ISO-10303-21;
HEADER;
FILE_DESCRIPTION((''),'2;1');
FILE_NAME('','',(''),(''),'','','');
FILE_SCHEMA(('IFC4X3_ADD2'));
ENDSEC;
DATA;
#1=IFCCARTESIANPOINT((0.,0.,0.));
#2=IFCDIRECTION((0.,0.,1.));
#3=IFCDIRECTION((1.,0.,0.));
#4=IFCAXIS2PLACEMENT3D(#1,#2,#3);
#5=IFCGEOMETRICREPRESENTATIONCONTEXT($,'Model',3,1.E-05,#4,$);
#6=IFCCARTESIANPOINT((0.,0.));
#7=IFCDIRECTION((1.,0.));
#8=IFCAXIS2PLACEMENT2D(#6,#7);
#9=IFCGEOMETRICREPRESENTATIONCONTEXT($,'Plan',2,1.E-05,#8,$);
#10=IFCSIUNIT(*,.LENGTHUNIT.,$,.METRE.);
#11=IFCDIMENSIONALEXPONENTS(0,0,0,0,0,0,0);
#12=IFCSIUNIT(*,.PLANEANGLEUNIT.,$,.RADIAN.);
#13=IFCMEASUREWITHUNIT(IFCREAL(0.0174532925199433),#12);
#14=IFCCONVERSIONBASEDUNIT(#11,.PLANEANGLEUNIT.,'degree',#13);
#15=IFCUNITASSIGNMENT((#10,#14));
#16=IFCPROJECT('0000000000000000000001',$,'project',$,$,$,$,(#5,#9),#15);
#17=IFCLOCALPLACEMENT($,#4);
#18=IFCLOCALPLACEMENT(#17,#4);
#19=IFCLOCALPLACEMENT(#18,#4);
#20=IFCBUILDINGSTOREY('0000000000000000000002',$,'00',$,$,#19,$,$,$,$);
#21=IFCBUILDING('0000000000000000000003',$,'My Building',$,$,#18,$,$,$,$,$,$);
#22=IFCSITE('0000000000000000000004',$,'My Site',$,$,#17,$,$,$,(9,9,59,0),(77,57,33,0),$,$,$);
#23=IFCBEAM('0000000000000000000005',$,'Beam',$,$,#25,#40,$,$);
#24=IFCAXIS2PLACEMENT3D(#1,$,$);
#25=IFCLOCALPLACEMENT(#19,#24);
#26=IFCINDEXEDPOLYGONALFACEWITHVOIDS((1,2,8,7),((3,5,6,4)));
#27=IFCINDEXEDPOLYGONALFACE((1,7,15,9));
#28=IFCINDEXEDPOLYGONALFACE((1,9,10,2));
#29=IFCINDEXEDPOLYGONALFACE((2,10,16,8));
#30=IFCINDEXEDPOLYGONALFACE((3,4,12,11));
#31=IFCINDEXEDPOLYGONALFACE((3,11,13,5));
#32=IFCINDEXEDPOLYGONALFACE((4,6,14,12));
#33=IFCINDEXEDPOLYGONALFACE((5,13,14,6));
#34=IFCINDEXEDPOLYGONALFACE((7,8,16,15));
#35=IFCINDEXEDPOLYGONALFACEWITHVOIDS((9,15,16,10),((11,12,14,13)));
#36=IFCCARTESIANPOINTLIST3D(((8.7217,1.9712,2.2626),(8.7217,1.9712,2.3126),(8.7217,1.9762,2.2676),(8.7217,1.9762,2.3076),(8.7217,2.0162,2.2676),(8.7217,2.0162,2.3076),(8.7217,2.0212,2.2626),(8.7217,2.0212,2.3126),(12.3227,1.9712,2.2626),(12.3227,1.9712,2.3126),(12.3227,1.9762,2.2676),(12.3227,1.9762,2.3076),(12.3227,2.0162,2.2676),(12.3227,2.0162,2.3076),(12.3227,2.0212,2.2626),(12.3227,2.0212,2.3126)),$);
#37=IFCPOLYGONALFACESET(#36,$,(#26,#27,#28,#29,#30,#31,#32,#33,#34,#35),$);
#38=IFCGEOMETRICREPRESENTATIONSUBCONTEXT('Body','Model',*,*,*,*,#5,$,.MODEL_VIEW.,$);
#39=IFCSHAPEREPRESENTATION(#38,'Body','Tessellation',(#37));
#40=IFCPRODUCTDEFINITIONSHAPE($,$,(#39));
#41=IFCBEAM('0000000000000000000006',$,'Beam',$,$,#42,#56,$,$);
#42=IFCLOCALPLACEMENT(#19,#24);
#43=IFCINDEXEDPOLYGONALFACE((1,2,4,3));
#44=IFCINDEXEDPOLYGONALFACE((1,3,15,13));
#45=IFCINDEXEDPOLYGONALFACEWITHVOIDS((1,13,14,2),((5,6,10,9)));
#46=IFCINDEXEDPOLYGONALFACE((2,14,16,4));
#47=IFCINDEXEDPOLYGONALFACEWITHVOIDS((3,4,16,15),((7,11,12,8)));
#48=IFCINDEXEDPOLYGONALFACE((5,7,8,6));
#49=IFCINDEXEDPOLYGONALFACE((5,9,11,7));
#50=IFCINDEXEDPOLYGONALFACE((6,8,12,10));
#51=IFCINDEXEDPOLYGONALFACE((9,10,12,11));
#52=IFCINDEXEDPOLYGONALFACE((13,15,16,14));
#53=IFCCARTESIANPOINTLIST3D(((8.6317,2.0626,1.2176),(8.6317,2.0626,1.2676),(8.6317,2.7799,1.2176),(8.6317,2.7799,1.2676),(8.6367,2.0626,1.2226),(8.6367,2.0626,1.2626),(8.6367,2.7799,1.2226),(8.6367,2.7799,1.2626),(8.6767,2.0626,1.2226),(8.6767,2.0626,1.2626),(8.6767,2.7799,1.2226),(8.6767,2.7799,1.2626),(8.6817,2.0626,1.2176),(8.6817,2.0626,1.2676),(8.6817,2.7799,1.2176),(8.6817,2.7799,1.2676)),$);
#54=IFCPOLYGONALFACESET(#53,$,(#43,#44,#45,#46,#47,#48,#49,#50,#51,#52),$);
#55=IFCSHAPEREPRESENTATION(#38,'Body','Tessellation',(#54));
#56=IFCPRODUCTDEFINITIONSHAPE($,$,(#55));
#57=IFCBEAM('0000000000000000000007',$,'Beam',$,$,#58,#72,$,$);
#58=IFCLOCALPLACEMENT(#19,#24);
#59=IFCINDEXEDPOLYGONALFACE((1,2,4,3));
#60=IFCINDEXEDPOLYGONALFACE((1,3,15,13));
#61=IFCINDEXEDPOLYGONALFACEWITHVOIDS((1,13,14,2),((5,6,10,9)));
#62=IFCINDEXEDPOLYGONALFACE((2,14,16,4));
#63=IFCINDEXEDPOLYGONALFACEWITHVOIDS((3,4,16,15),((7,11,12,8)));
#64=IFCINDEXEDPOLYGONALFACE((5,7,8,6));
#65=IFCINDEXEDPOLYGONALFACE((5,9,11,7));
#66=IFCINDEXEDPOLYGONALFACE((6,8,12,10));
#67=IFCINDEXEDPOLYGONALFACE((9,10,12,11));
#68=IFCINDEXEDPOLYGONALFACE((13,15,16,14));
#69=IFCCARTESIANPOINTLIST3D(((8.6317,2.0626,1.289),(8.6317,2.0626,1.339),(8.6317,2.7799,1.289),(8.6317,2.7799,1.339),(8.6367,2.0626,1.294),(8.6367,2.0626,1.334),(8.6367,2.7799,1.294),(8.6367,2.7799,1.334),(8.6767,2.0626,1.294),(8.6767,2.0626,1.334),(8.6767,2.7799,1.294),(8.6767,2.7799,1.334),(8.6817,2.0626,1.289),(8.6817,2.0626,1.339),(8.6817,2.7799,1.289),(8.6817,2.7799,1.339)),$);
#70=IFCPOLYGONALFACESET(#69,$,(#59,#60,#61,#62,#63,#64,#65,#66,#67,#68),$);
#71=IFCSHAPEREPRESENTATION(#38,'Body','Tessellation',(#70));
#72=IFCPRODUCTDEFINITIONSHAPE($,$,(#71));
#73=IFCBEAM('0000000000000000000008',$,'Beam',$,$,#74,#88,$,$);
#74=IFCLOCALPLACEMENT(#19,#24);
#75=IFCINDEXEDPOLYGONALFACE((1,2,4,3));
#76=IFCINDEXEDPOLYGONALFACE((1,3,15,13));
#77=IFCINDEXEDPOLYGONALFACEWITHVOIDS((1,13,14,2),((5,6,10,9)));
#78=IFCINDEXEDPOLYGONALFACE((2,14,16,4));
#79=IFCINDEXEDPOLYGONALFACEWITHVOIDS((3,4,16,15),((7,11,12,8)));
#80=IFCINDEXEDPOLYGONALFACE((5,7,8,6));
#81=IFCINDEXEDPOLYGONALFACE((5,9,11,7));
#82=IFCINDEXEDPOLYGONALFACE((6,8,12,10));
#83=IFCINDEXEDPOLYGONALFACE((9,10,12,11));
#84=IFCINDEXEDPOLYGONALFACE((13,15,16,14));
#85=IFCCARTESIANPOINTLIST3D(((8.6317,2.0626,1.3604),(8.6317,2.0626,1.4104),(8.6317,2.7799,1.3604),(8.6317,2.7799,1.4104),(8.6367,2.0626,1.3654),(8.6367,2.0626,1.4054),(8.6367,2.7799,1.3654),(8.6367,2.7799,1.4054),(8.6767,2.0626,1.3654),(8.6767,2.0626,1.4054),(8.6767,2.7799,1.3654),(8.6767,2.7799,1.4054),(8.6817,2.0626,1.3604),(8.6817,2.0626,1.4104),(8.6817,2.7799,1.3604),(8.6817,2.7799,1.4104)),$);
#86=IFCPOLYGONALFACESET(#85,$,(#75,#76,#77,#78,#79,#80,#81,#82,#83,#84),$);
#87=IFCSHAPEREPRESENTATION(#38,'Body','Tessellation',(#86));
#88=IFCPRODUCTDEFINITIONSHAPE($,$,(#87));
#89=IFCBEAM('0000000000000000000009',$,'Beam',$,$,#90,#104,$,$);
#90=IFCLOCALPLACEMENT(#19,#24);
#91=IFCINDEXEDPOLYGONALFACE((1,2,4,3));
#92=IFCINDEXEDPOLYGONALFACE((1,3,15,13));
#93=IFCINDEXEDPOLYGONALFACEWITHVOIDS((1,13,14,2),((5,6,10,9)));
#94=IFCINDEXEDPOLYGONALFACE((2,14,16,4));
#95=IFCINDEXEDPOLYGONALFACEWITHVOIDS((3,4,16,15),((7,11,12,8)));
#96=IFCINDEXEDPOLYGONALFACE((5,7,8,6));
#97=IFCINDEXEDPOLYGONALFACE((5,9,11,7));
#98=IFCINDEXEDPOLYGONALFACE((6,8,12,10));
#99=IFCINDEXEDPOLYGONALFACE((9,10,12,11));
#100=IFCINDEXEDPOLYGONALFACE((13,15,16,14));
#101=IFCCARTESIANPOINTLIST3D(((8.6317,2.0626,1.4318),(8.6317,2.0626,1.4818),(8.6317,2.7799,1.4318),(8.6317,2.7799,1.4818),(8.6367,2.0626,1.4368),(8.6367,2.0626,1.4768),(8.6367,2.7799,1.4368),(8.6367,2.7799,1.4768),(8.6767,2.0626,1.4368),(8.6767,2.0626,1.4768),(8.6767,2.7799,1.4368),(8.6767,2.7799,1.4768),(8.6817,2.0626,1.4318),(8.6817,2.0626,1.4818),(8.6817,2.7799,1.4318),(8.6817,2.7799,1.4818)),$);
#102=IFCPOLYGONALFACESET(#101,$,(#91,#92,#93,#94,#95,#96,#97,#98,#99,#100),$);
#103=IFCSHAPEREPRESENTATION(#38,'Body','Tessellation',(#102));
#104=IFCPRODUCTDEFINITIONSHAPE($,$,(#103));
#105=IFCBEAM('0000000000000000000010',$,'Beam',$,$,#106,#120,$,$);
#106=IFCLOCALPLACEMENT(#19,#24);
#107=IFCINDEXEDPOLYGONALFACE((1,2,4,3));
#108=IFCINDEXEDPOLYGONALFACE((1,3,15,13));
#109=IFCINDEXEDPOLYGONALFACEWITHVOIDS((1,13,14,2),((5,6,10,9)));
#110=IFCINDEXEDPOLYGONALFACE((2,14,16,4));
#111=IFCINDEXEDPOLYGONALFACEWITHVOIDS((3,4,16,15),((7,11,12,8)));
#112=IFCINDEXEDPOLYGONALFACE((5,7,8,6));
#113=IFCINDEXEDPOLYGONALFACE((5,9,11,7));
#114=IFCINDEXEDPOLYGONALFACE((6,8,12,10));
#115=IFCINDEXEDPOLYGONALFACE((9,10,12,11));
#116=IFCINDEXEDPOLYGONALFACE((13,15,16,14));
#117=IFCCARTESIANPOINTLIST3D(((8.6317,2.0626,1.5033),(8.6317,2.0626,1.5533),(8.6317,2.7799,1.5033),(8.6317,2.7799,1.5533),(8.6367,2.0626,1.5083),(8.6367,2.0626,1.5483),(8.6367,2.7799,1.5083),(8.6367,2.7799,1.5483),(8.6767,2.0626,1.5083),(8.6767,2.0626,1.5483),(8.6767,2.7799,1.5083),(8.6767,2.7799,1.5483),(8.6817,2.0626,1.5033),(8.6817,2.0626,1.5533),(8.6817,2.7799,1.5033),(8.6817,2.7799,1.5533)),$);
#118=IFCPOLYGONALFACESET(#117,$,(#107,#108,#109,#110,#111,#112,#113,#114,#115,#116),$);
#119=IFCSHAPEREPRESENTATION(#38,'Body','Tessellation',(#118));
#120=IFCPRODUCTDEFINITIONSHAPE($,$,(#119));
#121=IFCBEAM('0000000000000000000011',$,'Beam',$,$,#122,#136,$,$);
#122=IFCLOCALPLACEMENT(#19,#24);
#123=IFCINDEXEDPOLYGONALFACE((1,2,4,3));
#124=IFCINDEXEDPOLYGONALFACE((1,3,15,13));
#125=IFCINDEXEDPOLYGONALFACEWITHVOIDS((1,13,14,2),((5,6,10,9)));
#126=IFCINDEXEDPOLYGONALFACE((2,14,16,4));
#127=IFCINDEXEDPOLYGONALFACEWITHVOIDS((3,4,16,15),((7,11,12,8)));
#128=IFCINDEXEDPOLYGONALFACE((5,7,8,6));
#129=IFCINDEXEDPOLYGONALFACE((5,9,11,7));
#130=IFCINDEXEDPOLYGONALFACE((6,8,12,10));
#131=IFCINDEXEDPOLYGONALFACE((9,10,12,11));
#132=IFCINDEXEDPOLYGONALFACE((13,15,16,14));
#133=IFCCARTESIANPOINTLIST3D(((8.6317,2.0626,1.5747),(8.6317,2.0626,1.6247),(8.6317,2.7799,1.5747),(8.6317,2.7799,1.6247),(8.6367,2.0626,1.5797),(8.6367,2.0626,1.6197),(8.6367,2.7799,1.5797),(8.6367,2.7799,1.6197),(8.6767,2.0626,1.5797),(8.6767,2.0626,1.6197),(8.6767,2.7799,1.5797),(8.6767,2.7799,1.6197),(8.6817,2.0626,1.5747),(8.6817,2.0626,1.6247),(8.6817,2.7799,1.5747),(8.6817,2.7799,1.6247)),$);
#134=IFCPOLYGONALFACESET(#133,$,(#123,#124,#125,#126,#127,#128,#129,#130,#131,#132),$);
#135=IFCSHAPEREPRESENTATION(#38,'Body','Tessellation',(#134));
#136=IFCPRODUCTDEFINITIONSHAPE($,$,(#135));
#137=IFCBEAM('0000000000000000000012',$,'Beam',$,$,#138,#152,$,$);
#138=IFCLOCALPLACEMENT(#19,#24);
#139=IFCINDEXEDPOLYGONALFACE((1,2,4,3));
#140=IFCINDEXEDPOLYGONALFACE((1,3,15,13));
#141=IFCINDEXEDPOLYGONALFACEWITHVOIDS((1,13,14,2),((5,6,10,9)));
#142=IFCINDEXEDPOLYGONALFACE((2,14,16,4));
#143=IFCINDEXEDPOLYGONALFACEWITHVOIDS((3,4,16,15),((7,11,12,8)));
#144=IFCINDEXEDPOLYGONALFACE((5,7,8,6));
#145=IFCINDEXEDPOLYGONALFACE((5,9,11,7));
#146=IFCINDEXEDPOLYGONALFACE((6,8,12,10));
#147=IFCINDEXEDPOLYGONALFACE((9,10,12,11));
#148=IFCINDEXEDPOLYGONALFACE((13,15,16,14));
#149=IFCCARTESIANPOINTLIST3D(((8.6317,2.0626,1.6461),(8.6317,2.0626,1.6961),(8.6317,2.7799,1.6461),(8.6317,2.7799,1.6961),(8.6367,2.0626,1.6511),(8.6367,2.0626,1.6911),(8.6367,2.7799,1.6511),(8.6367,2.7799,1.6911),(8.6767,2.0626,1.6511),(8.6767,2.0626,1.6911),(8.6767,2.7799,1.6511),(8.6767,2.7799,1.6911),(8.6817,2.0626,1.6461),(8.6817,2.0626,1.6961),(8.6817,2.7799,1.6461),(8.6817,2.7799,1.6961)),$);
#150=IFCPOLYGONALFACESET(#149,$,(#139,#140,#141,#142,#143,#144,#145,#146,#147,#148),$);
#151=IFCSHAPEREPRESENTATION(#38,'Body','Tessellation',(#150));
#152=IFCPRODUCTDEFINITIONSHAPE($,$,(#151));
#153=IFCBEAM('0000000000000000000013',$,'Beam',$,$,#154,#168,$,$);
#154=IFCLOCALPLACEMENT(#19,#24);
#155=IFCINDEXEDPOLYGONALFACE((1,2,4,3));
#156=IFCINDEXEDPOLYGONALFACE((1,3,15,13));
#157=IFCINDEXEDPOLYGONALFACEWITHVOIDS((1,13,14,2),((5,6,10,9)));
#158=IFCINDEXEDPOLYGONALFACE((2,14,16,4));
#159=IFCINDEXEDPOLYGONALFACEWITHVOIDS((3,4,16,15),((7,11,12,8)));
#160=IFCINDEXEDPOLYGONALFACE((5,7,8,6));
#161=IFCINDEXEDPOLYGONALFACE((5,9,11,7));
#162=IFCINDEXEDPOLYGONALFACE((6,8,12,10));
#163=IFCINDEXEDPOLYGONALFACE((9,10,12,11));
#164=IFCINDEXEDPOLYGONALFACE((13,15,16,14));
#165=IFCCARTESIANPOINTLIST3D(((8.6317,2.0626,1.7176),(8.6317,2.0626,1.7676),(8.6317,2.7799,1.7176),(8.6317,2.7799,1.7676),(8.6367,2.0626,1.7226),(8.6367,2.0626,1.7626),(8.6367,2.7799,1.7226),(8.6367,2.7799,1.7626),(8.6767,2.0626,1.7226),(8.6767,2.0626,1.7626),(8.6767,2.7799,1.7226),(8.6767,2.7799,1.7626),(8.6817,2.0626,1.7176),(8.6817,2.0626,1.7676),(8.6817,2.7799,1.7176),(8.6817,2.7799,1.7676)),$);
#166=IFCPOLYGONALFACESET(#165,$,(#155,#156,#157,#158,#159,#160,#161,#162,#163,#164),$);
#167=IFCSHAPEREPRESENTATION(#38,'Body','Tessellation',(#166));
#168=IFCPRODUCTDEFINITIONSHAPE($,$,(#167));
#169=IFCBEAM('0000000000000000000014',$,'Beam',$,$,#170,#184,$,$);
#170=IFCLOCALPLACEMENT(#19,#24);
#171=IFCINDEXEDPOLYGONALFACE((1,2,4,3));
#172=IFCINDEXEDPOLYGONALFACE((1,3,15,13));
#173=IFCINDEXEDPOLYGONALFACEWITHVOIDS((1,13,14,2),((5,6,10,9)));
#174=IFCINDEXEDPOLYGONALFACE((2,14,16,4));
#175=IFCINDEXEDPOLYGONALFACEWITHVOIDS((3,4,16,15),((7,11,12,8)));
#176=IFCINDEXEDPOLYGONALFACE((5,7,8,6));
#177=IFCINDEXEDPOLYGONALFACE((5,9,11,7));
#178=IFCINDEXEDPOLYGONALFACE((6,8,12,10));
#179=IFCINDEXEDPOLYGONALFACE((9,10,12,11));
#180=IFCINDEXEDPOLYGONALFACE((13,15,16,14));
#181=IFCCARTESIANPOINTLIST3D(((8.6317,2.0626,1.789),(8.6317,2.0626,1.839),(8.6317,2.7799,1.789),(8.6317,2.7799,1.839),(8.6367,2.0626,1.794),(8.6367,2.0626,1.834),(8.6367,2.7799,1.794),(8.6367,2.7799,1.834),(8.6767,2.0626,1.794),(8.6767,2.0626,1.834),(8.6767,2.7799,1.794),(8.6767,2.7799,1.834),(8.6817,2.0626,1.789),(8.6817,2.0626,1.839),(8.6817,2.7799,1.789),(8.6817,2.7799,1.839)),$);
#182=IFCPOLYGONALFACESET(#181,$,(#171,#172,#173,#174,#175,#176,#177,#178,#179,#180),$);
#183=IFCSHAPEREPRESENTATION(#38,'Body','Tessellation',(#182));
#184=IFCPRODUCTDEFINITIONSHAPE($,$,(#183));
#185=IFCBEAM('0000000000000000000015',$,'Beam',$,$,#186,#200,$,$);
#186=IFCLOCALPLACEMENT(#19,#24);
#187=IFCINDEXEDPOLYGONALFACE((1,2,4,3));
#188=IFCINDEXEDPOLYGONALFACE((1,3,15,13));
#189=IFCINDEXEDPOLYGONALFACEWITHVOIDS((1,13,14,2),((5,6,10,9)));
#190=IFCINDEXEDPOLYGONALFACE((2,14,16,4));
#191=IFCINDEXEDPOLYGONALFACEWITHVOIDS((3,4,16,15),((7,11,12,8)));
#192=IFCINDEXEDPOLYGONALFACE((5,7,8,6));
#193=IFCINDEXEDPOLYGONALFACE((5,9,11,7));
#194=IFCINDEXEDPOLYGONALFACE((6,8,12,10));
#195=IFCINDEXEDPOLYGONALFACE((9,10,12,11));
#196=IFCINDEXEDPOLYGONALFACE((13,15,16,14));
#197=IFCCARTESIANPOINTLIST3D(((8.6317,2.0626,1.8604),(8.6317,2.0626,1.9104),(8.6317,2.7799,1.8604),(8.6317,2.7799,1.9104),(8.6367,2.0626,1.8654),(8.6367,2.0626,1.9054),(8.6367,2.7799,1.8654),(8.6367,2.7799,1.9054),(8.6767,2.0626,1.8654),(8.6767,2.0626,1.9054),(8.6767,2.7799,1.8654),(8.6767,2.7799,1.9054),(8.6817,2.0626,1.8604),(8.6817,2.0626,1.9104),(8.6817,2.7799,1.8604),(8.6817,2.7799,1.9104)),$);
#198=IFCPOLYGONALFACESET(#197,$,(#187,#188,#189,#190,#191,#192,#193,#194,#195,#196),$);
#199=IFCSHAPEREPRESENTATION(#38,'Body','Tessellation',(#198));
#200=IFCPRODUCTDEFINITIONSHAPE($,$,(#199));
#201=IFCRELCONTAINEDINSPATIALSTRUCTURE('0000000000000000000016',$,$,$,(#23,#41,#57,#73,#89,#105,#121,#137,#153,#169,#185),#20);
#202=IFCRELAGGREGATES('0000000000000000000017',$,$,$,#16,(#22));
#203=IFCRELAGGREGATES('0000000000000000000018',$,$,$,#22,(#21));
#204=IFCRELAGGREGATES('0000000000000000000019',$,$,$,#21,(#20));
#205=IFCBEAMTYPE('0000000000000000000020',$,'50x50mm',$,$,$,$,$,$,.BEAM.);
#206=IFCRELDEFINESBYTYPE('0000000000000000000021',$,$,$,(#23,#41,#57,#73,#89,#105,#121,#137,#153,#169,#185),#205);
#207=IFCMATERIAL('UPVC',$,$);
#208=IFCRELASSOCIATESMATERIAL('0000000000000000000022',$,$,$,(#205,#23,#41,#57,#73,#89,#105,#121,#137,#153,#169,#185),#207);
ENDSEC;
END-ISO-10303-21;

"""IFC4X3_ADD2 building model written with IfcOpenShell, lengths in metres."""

from ifc_helpers import new_model, entity, si_unit, converted_unit, frame, origin_with_axes, origin_2d_with_axis, place, context, subcontext, project, spatial, hollow_rectangle, extrude, material, material_profile, profile_set, profile_usage, type_object, element, save


model = new_model("IFC4X3_ADD2")

# Units and contexts
model_context = context("Model", 3, precision=1e-05, world=origin_with_axes())
plan_context = context("Plan", 2, precision=1e-05, world=origin_2d_with_axis())
body_context = subcontext(model_context, "Body", "Model", "MODEL_VIEW")
ifc_project = project(units=[si_unit("LENGTHUNIT", "METRE"), converted_unit("PLANEANGLEUNIT", "degree", entity("IfcReal", 0.0174532925199433), si_unit("PLANEANGLEUNIT", "RADIAN"), dimensions=[0, 0, 0, 0, 0, 0, 0])], contexts=[model_context, plan_context])

# Site, building, storey
site_placement = place(None, origin_with_axes())
site = spatial("IfcSite", under=ifc_project, at=site_placement, Name="My Site", RefLatitude=(9, 9, 59, 0), RefLongitude=(77, 57, 33, 0))
building_placement = place(site_placement, origin_with_axes())
building = spatial("IfcBuilding", under=site, at=building_placement, Name="My Building")
storey_placement = place(building_placement, origin_with_axes())
storey = spatial("IfcBuildingStorey", under=building, at=storey_placement, Name="00")

# Beams
ifc_material_1 = material(Name="UPVC")
ifc_material_profile_1 = material_profile(ifc_material_1, hollow_rectangle(XDim=0.05, YDim=0.05, WallThickness=0.005))
ifc_profile_set_1 = profile_set([ifc_material_profile_1])
beam_type = type_object("IfcBeamType", Name="50x50mm", PredefinedType="BEAM", material=ifc_profile_set_1)
ifc_profile_usage_1 = profile_usage(ifc_profile_set_1, cardinal=5)
beam_1_placement = place(storey_placement, frame((8.7217, 1.9962, 2.2876), z_axis=(1.0, 0.0, 0.000001), x_axis=(0.0, 1.0, 0.0)))
element("IfcBeam", 1, at=beam_1_placement, inside=storey, type_object=beam_type, material=ifc_profile_usage_1, Name="Beam", context=body_context, shape_type="SweptSolid", body=[
    extrude(hollow_rectangle(XDim=0.05, YDim=0.05, WallThickness=0.005), origin_with_axes(), (0.0, 0.0, 1.0), 3.601),
])
ifc_profile_usage_2 = profile_usage(ifc_profile_set_1, cardinal=5)
beam_2_placement = place(storey_placement, frame((8.6567, 2.0626, 1.2426), z_axis=(0.0, 1.0, 0.000001), x_axis=(-1.0, 0.0, 0.0)))
element("IfcBeam", 2, at=beam_2_placement, inside=storey, type_object=beam_type, material=ifc_profile_usage_2, Name="Beam", context=body_context, shape_type="SweptSolid", body=[
    extrude(hollow_rectangle(XDim=0.05, YDim=0.05, WallThickness=0.005), origin_with_axes(), (0.0, 0.0, 1.0), 0.7174),
])
ifc_profile_usage_3 = profile_usage(ifc_profile_set_1, cardinal=5)
beam_3_placement = place(storey_placement, frame((8.6567, 2.0626, 1.314), z_axis=(0.0, 1.0, 0.000001), x_axis=(-1.0, 0.0, 0.0)))
element("IfcBeam", 3, at=beam_3_placement, inside=storey, type_object=beam_type, material=ifc_profile_usage_3, Name="Beam", context=body_context, shape_type="SweptSolid", body=[
    extrude(hollow_rectangle(XDim=0.05, YDim=0.05, WallThickness=0.005), origin_with_axes(), (0.0, 0.0, 1.0), 0.7174),
])
ifc_profile_usage_4 = profile_usage(ifc_profile_set_1, cardinal=5)
beam_4_placement = place(storey_placement, frame((8.6567, 2.0626, 1.3854), z_axis=(0.0, 1.0, 0.000001), x_axis=(-1.0, 0.0, 0.0)))
element("IfcBeam", 4, at=beam_4_placement, inside=storey, type_object=beam_type, material=ifc_profile_usage_4, Name="Beam", context=body_context, shape_type="SweptSolid", body=[
    extrude(hollow_rectangle(XDim=0.05, YDim=0.05, WallThickness=0.005), origin_with_axes(), (0.0, 0.0, 1.0), 0.7174),
])
ifc_profile_usage_5 = profile_usage(ifc_profile_set_1, cardinal=5)
beam_5_placement = place(storey_placement, frame((8.6567, 2.0626, 1.4568), z_axis=(0.0, 1.0, 0.000001), x_axis=(-1.0, 0.0, 0.0)))
element("IfcBeam", 5, at=beam_5_placement, inside=storey, type_object=beam_type, material=ifc_profile_usage_5, Name="Beam", context=body_context, shape_type="SweptSolid", body=[
    extrude(hollow_rectangle(XDim=0.05, YDim=0.05, WallThickness=0.005), origin_with_axes(), (0.0, 0.0, 1.0), 0.7174),
])
ifc_profile_usage_6 = profile_usage(ifc_profile_set_1, cardinal=5)
beam_6_placement = place(storey_placement, frame((8.6567, 2.0626, 1.5283), z_axis=(0.0, 1.0, 0.000001), x_axis=(-1.0, 0.0, 0.0)))
element("IfcBeam", 6, at=beam_6_placement, inside=storey, type_object=beam_type, material=ifc_profile_usage_6, Name="Beam", context=body_context, shape_type="SweptSolid", body=[
    extrude(hollow_rectangle(XDim=0.05, YDim=0.05, WallThickness=0.005), origin_with_axes(), (0.0, 0.0, 1.0), 0.7174),
])
ifc_profile_usage_7 = profile_usage(ifc_profile_set_1, cardinal=5)
beam_7_placement = place(storey_placement, frame((8.6567, 2.0626, 1.5997), z_axis=(0.0, 1.0, 0.000001), x_axis=(-1.0, 0.0, 0.0)))
element("IfcBeam", 7, at=beam_7_placement, inside=storey, type_object=beam_type, material=ifc_profile_usage_7, Name="Beam", context=body_context, shape_type="SweptSolid", body=[
    extrude(hollow_rectangle(XDim=0.05, YDim=0.05, WallThickness=0.005), origin_with_axes(), (0.0, 0.0, 1.0), 0.7174),
])
ifc_profile_usage_8 = profile_usage(ifc_profile_set_1, cardinal=5)
beam_8_placement = place(storey_placement, frame((8.6567, 2.0626, 1.6711), z_axis=(0.0, 1.0, 0.000001), x_axis=(-1.0, 0.0, 0.0)))
element("IfcBeam", 8, at=beam_8_placement, inside=storey, type_object=beam_type, material=ifc_profile_usage_8, Name="Beam", context=body_context, shape_type="SweptSolid", body=[
    extrude(hollow_rectangle(XDim=0.05, YDim=0.05, WallThickness=0.005), origin_with_axes(), (0.0, 0.0, 1.0), 0.7174),
])
ifc_profile_usage_9 = profile_usage(ifc_profile_set_1, cardinal=5)
beam_9_placement = place(storey_placement, frame((8.6567, 2.0626, 1.7426), z_axis=(0.0, 1.0, 0.000001), x_axis=(-1.0, 0.0, 0.0)))
element("IfcBeam", 9, at=beam_9_placement, inside=storey, type_object=beam_type, material=ifc_profile_usage_9, Name="Beam", context=body_context, shape_type="SweptSolid", body=[
    extrude(hollow_rectangle(XDim=0.05, YDim=0.05, WallThickness=0.005), origin_with_axes(), (0.0, 0.0, 1.0), 0.7174),
])
ifc_profile_usage_10 = profile_usage(ifc_profile_set_1, cardinal=5)
beam_10_placement = place(storey_placement, frame((8.6567, 2.0626, 1.814), z_axis=(0.0, 1.0, 0.000001), x_axis=(-1.0, 0.0, 0.0)))
element("IfcBeam", 10, at=beam_10_placement, inside=storey, type_object=beam_type, material=ifc_profile_usage_10, Name="Beam", context=body_context, shape_type="SweptSolid", body=[
    extrude(hollow_rectangle(XDim=0.05, YDim=0.05, WallThickness=0.005), origin_with_axes(), (0.0, 0.0, 1.0), 0.7174),
])
ifc_profile_usage_11 = profile_usage(ifc_profile_set_1, cardinal=5)
beam_11_placement = place(storey_placement, frame((8.6567, 2.0626, 1.8854), z_axis=(0.0, 1.0, 0.000001), x_axis=(-1.0, 0.0, 0.0)))
element("IfcBeam", 11, at=beam_11_placement, inside=storey, type_object=beam_type, material=ifc_profile_usage_11, Name="Beam", context=body_context, shape_type="SweptSolid", body=[
    extrude(hollow_rectangle(XDim=0.05, YDim=0.05, WallThickness=0.005), origin_with_axes(), (0.0, 0.0, 1.0), 0.7174),
])

save(model, "model.ifc")
